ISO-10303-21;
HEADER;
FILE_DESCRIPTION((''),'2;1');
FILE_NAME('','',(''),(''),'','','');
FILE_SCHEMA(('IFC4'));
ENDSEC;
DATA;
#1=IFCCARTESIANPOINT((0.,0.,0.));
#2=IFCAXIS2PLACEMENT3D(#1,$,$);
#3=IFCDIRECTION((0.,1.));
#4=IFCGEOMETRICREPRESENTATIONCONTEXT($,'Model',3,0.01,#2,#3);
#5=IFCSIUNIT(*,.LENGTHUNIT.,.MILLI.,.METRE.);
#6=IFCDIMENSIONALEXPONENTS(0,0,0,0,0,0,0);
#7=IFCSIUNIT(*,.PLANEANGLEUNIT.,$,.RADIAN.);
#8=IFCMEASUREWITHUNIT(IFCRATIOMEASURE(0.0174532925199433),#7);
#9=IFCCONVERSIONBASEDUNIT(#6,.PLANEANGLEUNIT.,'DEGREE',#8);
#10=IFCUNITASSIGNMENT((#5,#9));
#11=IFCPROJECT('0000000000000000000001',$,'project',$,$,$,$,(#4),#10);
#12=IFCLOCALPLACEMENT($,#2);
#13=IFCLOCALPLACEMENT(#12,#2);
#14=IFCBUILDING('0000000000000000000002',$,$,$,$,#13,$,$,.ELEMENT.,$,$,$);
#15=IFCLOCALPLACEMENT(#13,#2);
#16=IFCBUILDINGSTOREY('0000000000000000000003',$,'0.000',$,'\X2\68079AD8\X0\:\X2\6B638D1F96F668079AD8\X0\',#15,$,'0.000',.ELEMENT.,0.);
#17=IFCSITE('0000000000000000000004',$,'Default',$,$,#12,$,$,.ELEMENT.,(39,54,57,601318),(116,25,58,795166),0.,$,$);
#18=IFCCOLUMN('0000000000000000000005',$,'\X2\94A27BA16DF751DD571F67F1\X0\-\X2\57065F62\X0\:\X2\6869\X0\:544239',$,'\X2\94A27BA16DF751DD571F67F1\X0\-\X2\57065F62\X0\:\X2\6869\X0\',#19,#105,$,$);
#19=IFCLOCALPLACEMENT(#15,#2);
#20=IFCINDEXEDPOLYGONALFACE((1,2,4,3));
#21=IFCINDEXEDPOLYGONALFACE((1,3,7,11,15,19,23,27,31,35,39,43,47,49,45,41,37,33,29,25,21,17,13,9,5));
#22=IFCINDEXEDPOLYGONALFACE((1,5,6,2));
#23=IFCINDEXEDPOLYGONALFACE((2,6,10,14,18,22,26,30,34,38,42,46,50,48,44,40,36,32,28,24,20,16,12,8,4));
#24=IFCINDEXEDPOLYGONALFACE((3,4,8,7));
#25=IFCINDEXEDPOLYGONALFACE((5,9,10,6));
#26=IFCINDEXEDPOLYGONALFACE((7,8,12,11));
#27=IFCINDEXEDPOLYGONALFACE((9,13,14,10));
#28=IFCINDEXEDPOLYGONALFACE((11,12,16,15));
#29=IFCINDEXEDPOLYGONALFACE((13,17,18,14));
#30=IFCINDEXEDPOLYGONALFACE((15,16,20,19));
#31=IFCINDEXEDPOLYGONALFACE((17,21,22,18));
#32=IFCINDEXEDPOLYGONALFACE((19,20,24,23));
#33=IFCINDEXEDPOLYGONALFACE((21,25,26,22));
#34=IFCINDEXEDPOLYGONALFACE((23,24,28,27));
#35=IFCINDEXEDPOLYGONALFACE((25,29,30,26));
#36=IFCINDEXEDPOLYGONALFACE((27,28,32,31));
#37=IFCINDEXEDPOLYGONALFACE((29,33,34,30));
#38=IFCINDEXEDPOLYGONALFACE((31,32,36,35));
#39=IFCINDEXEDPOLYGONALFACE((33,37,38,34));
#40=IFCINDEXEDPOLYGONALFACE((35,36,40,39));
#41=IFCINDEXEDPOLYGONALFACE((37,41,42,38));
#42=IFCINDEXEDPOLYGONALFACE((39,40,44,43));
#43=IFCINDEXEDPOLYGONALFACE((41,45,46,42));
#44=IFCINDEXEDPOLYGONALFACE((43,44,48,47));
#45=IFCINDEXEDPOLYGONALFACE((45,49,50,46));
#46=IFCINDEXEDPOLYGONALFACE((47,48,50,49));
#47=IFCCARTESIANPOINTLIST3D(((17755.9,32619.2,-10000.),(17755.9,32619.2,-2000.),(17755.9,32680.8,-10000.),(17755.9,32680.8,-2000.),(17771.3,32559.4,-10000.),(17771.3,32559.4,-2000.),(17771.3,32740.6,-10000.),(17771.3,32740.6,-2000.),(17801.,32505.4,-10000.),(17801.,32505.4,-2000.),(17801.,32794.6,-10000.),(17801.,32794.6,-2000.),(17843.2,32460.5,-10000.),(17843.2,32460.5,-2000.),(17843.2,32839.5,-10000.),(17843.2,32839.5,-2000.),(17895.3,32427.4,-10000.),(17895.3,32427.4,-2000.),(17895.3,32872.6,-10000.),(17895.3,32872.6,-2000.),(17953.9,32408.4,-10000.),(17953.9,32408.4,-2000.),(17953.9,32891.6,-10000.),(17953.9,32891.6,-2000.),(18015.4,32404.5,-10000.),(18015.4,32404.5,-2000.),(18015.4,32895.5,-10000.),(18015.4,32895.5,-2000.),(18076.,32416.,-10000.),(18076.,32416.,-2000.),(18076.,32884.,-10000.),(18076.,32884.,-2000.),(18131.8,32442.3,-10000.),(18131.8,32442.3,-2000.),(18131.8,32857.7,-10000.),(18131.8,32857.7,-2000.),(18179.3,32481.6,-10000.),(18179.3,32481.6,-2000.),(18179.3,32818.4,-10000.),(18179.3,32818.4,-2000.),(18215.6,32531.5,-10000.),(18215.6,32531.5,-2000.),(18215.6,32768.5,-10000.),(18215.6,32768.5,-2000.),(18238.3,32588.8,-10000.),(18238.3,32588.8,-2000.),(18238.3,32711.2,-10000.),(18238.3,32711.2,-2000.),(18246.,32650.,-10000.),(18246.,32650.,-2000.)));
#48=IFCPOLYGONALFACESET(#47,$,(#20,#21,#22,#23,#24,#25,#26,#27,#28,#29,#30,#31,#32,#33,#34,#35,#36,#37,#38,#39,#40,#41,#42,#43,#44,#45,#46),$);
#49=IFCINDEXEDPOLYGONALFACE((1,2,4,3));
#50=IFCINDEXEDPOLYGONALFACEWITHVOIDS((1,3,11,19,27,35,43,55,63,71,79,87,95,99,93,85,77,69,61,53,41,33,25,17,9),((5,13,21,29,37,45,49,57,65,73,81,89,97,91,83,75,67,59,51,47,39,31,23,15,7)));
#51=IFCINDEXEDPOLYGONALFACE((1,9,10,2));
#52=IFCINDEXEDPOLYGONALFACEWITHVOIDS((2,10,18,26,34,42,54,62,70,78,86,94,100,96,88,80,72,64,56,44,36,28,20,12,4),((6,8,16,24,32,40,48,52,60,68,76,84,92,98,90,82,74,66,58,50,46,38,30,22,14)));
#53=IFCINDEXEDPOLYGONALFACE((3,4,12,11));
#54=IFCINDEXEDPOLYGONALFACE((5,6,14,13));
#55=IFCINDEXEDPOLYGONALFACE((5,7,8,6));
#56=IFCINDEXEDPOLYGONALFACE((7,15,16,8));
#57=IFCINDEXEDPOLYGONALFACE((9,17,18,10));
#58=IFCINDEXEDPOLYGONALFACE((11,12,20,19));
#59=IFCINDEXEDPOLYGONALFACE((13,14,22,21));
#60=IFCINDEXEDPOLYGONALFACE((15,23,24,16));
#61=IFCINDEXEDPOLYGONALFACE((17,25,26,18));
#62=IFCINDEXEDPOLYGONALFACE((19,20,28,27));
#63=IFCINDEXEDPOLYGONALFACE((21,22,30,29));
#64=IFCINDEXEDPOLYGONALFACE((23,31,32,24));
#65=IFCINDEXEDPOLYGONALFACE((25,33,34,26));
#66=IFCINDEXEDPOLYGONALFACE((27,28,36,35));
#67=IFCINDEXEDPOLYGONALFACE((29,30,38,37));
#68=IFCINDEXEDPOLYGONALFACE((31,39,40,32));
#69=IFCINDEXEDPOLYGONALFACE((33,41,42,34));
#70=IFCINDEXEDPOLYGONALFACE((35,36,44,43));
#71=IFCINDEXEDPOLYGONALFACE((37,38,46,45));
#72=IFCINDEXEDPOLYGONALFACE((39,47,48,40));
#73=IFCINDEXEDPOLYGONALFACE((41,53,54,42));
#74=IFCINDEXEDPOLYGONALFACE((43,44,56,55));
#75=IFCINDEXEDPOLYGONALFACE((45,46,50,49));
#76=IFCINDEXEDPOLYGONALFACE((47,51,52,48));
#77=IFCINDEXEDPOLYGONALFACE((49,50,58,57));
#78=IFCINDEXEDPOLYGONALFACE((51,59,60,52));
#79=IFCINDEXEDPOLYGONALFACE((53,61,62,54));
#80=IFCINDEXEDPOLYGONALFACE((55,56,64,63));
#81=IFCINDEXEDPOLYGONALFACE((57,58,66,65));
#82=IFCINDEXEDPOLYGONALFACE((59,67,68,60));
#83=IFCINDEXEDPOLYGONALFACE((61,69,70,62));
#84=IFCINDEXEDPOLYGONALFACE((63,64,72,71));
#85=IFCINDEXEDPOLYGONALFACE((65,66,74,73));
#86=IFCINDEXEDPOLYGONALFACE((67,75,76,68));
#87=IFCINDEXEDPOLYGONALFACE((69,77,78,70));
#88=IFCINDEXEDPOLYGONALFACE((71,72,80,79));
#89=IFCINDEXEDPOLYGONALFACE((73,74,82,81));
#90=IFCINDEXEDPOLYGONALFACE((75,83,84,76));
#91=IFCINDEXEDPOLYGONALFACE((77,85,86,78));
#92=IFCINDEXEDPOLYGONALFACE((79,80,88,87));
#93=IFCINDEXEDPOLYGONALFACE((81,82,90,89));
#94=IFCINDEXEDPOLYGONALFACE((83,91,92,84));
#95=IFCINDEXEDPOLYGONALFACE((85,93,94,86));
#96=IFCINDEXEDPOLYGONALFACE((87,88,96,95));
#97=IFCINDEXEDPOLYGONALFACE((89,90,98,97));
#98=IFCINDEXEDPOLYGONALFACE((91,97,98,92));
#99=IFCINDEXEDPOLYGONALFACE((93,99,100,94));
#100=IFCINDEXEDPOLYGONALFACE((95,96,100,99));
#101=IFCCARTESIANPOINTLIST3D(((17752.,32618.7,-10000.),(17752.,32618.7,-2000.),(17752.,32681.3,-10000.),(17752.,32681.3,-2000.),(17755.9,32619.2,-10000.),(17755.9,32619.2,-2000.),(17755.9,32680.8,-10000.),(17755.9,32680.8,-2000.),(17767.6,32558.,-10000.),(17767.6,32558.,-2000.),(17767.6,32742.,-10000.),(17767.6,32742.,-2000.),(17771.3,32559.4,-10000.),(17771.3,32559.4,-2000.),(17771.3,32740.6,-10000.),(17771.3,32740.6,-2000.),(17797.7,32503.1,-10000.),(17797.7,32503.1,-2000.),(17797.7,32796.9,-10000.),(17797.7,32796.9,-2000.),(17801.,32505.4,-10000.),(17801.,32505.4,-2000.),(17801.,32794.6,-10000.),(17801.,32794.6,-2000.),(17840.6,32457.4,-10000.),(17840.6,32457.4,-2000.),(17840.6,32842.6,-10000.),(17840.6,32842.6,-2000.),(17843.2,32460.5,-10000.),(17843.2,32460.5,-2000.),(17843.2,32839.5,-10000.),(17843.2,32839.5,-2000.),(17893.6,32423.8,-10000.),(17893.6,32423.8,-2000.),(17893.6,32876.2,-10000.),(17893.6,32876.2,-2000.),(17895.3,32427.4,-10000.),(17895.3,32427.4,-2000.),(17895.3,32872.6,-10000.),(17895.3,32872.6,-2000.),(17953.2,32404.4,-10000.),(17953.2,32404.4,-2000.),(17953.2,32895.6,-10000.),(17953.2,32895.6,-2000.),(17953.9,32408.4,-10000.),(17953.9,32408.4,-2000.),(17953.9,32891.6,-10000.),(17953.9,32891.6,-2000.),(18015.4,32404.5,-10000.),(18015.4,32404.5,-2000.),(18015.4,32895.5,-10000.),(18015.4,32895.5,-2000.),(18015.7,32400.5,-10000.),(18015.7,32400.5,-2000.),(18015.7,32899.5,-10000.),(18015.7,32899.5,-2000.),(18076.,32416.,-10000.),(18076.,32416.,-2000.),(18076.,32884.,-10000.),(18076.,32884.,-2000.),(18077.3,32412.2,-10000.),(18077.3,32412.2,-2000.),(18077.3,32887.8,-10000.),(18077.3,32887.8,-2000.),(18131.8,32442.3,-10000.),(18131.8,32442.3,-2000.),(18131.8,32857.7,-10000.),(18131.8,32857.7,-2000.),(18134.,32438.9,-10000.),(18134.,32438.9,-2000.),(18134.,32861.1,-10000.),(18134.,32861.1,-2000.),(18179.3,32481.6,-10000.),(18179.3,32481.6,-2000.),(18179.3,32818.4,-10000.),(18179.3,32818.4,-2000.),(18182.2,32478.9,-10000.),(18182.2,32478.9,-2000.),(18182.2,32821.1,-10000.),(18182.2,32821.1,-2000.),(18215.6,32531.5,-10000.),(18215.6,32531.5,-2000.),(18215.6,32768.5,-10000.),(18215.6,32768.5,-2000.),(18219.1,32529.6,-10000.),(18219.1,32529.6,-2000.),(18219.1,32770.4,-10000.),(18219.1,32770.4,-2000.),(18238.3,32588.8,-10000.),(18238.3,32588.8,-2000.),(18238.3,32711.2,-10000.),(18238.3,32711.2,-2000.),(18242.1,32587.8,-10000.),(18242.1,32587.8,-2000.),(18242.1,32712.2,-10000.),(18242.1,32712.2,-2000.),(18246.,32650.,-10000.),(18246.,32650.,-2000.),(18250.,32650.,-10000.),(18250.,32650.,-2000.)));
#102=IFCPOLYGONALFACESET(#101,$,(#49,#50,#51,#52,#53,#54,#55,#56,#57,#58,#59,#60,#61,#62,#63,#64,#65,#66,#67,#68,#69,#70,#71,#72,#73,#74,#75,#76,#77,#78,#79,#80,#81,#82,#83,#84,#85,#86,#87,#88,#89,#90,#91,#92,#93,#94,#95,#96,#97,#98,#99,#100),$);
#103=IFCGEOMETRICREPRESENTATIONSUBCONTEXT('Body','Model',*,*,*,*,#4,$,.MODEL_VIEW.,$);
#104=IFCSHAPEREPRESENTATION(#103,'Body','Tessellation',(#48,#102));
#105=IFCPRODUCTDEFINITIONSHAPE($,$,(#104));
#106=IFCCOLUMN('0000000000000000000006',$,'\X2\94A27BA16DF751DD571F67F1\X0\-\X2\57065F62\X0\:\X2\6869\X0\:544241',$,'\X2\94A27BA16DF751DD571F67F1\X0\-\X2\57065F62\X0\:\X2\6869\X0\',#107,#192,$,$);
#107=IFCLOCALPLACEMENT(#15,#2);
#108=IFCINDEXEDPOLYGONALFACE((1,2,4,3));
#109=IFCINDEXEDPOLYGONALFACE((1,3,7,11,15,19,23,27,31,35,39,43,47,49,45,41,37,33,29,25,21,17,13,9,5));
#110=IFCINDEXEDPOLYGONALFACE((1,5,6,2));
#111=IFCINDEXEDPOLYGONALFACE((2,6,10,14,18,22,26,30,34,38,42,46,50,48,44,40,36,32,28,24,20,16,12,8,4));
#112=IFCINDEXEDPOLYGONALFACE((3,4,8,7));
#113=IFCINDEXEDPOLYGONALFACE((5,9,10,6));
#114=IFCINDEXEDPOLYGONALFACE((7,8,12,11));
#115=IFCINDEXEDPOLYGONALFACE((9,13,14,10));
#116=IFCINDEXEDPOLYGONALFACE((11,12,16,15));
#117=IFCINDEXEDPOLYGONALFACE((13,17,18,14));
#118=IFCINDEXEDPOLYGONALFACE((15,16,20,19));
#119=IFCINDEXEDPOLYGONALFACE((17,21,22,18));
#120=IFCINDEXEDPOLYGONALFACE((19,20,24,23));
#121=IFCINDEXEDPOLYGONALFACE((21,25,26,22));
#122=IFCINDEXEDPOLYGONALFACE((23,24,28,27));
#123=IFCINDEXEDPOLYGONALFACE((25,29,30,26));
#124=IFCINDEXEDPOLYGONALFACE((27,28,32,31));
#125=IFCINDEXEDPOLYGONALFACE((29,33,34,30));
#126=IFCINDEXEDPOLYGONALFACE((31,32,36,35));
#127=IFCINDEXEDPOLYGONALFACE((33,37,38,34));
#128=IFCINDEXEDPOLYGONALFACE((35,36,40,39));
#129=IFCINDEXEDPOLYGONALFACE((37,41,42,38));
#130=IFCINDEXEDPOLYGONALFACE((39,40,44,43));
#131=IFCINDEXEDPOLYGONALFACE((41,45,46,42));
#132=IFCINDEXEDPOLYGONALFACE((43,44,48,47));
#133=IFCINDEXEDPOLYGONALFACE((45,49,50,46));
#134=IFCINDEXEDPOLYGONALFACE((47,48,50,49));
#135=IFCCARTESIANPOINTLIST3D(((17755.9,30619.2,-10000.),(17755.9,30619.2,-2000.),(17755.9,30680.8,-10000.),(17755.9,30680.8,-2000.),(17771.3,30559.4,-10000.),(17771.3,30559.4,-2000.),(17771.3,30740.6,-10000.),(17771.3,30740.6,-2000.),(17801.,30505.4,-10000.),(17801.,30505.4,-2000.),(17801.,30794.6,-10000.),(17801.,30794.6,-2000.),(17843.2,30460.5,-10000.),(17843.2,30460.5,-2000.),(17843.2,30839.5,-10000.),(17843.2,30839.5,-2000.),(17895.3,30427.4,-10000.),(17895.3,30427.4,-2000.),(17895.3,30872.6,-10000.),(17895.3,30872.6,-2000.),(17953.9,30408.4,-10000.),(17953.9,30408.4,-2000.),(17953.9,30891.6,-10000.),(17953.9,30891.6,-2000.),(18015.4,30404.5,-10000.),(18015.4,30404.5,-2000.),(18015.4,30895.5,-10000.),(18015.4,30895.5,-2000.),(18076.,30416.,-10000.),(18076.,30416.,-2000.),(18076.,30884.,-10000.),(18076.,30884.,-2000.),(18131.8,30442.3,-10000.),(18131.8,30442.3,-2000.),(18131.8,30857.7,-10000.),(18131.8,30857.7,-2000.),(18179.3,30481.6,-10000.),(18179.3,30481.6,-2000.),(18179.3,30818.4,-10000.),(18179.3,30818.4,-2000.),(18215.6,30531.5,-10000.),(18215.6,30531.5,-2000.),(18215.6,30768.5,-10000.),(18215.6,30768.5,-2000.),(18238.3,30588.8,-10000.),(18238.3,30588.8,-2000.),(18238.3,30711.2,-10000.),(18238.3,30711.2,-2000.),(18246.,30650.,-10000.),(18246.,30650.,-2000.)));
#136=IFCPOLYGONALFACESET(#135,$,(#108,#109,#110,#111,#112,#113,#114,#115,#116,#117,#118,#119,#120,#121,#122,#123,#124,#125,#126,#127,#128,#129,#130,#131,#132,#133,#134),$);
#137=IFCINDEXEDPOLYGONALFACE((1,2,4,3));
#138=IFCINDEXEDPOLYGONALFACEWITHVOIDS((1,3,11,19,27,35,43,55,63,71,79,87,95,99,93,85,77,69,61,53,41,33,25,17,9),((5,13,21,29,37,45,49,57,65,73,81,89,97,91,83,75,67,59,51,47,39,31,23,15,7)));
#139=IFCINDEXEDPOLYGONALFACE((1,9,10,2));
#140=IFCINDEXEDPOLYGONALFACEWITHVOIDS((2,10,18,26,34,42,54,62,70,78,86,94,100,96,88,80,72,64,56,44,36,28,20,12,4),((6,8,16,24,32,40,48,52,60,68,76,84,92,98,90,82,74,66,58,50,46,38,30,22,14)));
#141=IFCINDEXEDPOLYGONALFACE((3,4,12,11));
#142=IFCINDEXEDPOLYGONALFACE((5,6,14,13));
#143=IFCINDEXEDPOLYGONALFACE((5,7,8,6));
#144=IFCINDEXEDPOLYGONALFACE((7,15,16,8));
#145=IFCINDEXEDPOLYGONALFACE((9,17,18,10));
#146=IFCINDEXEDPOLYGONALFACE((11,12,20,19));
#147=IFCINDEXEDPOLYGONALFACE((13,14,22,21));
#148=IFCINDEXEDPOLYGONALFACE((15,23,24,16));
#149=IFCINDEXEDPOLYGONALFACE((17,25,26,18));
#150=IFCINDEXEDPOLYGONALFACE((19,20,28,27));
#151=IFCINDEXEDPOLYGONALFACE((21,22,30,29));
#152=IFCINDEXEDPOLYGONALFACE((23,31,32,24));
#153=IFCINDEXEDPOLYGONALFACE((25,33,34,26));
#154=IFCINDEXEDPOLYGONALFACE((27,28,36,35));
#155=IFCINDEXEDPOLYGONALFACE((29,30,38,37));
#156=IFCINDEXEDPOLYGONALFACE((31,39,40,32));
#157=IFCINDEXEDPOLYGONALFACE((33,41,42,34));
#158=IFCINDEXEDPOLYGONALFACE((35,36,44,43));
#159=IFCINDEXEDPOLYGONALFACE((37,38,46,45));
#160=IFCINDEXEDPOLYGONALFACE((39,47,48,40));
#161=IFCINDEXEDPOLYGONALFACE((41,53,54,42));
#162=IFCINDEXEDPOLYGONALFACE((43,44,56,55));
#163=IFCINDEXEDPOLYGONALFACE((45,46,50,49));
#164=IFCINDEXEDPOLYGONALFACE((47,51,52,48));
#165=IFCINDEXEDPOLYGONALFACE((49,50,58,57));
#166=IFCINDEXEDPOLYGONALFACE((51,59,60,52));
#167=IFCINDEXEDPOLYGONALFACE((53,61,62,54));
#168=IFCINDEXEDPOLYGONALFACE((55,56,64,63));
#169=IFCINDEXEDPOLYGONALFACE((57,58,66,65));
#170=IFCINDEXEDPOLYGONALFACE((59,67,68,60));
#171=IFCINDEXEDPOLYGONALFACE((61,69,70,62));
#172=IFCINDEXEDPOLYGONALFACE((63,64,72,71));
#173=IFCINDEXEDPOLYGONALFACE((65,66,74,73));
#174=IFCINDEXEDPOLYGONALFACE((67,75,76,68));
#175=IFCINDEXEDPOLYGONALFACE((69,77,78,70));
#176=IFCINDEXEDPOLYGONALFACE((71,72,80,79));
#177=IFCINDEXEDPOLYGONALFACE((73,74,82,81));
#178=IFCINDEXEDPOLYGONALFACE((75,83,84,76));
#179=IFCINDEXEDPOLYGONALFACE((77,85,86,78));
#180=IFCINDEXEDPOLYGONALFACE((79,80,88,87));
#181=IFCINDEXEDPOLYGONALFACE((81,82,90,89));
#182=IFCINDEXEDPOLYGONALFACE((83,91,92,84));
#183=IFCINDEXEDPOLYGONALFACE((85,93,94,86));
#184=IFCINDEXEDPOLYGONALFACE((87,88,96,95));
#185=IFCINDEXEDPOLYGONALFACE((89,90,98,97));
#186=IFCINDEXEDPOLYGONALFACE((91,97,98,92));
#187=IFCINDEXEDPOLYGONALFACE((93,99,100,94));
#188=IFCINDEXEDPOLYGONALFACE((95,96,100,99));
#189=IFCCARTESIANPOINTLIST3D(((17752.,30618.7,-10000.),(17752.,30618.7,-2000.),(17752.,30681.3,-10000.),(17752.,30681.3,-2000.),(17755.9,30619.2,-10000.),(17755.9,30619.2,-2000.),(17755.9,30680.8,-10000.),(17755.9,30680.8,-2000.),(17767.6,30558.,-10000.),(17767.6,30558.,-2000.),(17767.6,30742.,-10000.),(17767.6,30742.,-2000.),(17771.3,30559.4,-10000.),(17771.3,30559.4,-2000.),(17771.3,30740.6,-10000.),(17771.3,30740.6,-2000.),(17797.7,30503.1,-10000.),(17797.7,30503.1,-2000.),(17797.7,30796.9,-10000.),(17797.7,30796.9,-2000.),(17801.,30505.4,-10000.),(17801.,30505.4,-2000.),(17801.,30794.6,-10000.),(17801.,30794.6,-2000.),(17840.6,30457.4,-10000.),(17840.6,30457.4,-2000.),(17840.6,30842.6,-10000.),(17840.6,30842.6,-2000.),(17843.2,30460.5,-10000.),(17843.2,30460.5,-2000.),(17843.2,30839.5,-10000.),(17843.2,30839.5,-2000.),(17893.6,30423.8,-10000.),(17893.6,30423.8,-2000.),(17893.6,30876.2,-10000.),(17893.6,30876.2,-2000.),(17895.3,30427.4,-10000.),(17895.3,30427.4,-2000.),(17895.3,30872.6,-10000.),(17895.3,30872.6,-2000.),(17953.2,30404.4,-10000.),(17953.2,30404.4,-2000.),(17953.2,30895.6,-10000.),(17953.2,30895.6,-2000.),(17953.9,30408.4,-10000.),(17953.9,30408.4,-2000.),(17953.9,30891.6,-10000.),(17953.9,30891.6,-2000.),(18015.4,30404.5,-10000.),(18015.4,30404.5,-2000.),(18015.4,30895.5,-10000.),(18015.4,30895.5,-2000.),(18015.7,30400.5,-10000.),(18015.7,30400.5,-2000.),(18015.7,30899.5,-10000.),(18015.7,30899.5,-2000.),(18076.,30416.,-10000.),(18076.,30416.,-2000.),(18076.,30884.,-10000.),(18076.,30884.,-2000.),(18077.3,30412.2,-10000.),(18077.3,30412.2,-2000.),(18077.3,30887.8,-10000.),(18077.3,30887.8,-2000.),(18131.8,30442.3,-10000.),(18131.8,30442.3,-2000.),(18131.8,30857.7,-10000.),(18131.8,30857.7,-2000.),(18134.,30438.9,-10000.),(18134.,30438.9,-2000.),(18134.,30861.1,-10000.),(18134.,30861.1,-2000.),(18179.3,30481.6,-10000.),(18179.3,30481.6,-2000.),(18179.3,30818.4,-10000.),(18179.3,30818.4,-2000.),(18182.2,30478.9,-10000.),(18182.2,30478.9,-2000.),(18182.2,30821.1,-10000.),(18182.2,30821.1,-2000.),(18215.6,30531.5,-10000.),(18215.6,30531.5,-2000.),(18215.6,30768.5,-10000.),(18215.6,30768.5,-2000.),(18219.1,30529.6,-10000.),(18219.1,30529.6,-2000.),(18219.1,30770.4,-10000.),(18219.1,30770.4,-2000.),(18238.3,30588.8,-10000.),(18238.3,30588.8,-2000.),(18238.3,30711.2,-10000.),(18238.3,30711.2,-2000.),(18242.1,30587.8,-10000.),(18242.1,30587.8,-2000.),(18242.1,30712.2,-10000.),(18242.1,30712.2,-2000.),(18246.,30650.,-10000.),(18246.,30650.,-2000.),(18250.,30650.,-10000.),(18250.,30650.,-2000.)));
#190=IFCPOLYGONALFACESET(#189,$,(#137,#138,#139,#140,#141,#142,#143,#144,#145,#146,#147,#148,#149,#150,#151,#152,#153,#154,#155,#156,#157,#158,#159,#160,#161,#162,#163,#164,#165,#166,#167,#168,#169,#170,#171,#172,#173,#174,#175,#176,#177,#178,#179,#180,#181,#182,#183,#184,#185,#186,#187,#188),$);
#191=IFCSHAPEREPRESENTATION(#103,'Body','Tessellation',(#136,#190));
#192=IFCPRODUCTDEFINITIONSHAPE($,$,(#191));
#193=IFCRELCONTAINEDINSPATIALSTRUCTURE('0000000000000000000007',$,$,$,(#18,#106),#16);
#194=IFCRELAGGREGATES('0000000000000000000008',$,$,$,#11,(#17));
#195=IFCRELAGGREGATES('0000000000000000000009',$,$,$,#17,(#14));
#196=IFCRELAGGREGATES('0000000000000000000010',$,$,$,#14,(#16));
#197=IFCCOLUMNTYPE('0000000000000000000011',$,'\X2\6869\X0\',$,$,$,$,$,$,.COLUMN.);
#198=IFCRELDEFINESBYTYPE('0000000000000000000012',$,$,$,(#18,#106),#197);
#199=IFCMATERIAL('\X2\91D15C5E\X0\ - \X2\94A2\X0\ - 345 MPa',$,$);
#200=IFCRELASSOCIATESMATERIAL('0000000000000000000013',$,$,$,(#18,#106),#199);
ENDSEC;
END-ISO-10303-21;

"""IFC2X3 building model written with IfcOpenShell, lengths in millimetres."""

from ifc_helpers import new_model, entity, si_unit, converted_unit, direction, frame, frame_2d, origin, place, context, subcontext, project, spatial, circle, hollow_circle, extrude, source, transform, mapped, material, type_object, type_shapes, element, save


model = new_model("IFC2X3")

# Units and contexts
model_context = context("Model", 3, precision=0.01, world=origin(), true_north=direction((0.0, 1.0)))
body_context = subcontext(model_context, "Body", "Model", "MODEL_VIEW")
ifc_project = project(units=[si_unit("LENGTHUNIT", "METRE", prefix="MILLI"), converted_unit("PLANEANGLEUNIT", "DEGREE", entity("IfcRatioMeasure", 0.0174532925199433), si_unit("PLANEANGLEUNIT", "RADIAN"), dimensions=[0, 0, 0, 0, 0, 0, 0])], contexts=[model_context])

# Site, building, storey
site_placement = place(None, origin())
site = spatial("IfcSite", under=ifc_project, at=site_placement, Name="Default", CompositionType="ELEMENT", RefLatitude=(39, 54, 57, 601318), RefLongitude=(116, 25, 58, 795166), RefElevation=0.0)
building_placement = place(site_placement, origin())
building = spatial("IfcBuilding", under=site, at=building_placement, CompositionType="ELEMENT")
storey_placement = place(building_placement, origin())
storey = spatial("IfcBuildingStorey", under=building, at=storey_placement, Name="0.000", ObjectType="标高:正负零标高", LongName="0.000", CompositionType="ELEMENT", Elevation=0.0)

# Columns
ifc_material_1 = material(Name="金属 - 钢 - 345 MPa")
column_type = type_object("IfcColumnType", Name="桩", PredefinedType="COLUMN")
shared_shape = source(origin(), body_context, "Body", "SweptSolid", [
    extrude(circle(Radius=246.0, at=frame_2d((0.0, 0.0), x_axis=(1.0, 0.0))), frame((0.0, 0.0, -10000.0)), (0.0, 0.0, 1.0), 8000.0),
    extrude(hollow_circle(Radius=250.0, WallThickness=4.0, at=frame_2d((0.0, 0.0), x_axis=(1.0, 0.0))), frame((0.0, 0.0, -10000.0)), (0.0, 0.0, 1.0), 8000.0),
])
type_shapes(column_type, [shared_shape])
for number, where, name in (
    (1, (18000.0, 32650.0, 0.0), "钢管混凝土柱-圆形:桩:544239"),
    (2, (18000.0, 30650.0, 0.0), "钢管混凝土柱-圆形:桩:544241"),
):
    element("IfcColumn", number, at=place(storey_placement, frame(where)), inside=storey, type_object=column_type, material=ifc_material_1, Name=name, ObjectType="钢管混凝土柱-圆形:桩", context=body_context, shape_type="MappedRepresentation", body=[
        mapped(shared_shape, transform((0.0, 0.0, 0.0), scale=1.0)),
    ])

save(model, "model.ifc")
